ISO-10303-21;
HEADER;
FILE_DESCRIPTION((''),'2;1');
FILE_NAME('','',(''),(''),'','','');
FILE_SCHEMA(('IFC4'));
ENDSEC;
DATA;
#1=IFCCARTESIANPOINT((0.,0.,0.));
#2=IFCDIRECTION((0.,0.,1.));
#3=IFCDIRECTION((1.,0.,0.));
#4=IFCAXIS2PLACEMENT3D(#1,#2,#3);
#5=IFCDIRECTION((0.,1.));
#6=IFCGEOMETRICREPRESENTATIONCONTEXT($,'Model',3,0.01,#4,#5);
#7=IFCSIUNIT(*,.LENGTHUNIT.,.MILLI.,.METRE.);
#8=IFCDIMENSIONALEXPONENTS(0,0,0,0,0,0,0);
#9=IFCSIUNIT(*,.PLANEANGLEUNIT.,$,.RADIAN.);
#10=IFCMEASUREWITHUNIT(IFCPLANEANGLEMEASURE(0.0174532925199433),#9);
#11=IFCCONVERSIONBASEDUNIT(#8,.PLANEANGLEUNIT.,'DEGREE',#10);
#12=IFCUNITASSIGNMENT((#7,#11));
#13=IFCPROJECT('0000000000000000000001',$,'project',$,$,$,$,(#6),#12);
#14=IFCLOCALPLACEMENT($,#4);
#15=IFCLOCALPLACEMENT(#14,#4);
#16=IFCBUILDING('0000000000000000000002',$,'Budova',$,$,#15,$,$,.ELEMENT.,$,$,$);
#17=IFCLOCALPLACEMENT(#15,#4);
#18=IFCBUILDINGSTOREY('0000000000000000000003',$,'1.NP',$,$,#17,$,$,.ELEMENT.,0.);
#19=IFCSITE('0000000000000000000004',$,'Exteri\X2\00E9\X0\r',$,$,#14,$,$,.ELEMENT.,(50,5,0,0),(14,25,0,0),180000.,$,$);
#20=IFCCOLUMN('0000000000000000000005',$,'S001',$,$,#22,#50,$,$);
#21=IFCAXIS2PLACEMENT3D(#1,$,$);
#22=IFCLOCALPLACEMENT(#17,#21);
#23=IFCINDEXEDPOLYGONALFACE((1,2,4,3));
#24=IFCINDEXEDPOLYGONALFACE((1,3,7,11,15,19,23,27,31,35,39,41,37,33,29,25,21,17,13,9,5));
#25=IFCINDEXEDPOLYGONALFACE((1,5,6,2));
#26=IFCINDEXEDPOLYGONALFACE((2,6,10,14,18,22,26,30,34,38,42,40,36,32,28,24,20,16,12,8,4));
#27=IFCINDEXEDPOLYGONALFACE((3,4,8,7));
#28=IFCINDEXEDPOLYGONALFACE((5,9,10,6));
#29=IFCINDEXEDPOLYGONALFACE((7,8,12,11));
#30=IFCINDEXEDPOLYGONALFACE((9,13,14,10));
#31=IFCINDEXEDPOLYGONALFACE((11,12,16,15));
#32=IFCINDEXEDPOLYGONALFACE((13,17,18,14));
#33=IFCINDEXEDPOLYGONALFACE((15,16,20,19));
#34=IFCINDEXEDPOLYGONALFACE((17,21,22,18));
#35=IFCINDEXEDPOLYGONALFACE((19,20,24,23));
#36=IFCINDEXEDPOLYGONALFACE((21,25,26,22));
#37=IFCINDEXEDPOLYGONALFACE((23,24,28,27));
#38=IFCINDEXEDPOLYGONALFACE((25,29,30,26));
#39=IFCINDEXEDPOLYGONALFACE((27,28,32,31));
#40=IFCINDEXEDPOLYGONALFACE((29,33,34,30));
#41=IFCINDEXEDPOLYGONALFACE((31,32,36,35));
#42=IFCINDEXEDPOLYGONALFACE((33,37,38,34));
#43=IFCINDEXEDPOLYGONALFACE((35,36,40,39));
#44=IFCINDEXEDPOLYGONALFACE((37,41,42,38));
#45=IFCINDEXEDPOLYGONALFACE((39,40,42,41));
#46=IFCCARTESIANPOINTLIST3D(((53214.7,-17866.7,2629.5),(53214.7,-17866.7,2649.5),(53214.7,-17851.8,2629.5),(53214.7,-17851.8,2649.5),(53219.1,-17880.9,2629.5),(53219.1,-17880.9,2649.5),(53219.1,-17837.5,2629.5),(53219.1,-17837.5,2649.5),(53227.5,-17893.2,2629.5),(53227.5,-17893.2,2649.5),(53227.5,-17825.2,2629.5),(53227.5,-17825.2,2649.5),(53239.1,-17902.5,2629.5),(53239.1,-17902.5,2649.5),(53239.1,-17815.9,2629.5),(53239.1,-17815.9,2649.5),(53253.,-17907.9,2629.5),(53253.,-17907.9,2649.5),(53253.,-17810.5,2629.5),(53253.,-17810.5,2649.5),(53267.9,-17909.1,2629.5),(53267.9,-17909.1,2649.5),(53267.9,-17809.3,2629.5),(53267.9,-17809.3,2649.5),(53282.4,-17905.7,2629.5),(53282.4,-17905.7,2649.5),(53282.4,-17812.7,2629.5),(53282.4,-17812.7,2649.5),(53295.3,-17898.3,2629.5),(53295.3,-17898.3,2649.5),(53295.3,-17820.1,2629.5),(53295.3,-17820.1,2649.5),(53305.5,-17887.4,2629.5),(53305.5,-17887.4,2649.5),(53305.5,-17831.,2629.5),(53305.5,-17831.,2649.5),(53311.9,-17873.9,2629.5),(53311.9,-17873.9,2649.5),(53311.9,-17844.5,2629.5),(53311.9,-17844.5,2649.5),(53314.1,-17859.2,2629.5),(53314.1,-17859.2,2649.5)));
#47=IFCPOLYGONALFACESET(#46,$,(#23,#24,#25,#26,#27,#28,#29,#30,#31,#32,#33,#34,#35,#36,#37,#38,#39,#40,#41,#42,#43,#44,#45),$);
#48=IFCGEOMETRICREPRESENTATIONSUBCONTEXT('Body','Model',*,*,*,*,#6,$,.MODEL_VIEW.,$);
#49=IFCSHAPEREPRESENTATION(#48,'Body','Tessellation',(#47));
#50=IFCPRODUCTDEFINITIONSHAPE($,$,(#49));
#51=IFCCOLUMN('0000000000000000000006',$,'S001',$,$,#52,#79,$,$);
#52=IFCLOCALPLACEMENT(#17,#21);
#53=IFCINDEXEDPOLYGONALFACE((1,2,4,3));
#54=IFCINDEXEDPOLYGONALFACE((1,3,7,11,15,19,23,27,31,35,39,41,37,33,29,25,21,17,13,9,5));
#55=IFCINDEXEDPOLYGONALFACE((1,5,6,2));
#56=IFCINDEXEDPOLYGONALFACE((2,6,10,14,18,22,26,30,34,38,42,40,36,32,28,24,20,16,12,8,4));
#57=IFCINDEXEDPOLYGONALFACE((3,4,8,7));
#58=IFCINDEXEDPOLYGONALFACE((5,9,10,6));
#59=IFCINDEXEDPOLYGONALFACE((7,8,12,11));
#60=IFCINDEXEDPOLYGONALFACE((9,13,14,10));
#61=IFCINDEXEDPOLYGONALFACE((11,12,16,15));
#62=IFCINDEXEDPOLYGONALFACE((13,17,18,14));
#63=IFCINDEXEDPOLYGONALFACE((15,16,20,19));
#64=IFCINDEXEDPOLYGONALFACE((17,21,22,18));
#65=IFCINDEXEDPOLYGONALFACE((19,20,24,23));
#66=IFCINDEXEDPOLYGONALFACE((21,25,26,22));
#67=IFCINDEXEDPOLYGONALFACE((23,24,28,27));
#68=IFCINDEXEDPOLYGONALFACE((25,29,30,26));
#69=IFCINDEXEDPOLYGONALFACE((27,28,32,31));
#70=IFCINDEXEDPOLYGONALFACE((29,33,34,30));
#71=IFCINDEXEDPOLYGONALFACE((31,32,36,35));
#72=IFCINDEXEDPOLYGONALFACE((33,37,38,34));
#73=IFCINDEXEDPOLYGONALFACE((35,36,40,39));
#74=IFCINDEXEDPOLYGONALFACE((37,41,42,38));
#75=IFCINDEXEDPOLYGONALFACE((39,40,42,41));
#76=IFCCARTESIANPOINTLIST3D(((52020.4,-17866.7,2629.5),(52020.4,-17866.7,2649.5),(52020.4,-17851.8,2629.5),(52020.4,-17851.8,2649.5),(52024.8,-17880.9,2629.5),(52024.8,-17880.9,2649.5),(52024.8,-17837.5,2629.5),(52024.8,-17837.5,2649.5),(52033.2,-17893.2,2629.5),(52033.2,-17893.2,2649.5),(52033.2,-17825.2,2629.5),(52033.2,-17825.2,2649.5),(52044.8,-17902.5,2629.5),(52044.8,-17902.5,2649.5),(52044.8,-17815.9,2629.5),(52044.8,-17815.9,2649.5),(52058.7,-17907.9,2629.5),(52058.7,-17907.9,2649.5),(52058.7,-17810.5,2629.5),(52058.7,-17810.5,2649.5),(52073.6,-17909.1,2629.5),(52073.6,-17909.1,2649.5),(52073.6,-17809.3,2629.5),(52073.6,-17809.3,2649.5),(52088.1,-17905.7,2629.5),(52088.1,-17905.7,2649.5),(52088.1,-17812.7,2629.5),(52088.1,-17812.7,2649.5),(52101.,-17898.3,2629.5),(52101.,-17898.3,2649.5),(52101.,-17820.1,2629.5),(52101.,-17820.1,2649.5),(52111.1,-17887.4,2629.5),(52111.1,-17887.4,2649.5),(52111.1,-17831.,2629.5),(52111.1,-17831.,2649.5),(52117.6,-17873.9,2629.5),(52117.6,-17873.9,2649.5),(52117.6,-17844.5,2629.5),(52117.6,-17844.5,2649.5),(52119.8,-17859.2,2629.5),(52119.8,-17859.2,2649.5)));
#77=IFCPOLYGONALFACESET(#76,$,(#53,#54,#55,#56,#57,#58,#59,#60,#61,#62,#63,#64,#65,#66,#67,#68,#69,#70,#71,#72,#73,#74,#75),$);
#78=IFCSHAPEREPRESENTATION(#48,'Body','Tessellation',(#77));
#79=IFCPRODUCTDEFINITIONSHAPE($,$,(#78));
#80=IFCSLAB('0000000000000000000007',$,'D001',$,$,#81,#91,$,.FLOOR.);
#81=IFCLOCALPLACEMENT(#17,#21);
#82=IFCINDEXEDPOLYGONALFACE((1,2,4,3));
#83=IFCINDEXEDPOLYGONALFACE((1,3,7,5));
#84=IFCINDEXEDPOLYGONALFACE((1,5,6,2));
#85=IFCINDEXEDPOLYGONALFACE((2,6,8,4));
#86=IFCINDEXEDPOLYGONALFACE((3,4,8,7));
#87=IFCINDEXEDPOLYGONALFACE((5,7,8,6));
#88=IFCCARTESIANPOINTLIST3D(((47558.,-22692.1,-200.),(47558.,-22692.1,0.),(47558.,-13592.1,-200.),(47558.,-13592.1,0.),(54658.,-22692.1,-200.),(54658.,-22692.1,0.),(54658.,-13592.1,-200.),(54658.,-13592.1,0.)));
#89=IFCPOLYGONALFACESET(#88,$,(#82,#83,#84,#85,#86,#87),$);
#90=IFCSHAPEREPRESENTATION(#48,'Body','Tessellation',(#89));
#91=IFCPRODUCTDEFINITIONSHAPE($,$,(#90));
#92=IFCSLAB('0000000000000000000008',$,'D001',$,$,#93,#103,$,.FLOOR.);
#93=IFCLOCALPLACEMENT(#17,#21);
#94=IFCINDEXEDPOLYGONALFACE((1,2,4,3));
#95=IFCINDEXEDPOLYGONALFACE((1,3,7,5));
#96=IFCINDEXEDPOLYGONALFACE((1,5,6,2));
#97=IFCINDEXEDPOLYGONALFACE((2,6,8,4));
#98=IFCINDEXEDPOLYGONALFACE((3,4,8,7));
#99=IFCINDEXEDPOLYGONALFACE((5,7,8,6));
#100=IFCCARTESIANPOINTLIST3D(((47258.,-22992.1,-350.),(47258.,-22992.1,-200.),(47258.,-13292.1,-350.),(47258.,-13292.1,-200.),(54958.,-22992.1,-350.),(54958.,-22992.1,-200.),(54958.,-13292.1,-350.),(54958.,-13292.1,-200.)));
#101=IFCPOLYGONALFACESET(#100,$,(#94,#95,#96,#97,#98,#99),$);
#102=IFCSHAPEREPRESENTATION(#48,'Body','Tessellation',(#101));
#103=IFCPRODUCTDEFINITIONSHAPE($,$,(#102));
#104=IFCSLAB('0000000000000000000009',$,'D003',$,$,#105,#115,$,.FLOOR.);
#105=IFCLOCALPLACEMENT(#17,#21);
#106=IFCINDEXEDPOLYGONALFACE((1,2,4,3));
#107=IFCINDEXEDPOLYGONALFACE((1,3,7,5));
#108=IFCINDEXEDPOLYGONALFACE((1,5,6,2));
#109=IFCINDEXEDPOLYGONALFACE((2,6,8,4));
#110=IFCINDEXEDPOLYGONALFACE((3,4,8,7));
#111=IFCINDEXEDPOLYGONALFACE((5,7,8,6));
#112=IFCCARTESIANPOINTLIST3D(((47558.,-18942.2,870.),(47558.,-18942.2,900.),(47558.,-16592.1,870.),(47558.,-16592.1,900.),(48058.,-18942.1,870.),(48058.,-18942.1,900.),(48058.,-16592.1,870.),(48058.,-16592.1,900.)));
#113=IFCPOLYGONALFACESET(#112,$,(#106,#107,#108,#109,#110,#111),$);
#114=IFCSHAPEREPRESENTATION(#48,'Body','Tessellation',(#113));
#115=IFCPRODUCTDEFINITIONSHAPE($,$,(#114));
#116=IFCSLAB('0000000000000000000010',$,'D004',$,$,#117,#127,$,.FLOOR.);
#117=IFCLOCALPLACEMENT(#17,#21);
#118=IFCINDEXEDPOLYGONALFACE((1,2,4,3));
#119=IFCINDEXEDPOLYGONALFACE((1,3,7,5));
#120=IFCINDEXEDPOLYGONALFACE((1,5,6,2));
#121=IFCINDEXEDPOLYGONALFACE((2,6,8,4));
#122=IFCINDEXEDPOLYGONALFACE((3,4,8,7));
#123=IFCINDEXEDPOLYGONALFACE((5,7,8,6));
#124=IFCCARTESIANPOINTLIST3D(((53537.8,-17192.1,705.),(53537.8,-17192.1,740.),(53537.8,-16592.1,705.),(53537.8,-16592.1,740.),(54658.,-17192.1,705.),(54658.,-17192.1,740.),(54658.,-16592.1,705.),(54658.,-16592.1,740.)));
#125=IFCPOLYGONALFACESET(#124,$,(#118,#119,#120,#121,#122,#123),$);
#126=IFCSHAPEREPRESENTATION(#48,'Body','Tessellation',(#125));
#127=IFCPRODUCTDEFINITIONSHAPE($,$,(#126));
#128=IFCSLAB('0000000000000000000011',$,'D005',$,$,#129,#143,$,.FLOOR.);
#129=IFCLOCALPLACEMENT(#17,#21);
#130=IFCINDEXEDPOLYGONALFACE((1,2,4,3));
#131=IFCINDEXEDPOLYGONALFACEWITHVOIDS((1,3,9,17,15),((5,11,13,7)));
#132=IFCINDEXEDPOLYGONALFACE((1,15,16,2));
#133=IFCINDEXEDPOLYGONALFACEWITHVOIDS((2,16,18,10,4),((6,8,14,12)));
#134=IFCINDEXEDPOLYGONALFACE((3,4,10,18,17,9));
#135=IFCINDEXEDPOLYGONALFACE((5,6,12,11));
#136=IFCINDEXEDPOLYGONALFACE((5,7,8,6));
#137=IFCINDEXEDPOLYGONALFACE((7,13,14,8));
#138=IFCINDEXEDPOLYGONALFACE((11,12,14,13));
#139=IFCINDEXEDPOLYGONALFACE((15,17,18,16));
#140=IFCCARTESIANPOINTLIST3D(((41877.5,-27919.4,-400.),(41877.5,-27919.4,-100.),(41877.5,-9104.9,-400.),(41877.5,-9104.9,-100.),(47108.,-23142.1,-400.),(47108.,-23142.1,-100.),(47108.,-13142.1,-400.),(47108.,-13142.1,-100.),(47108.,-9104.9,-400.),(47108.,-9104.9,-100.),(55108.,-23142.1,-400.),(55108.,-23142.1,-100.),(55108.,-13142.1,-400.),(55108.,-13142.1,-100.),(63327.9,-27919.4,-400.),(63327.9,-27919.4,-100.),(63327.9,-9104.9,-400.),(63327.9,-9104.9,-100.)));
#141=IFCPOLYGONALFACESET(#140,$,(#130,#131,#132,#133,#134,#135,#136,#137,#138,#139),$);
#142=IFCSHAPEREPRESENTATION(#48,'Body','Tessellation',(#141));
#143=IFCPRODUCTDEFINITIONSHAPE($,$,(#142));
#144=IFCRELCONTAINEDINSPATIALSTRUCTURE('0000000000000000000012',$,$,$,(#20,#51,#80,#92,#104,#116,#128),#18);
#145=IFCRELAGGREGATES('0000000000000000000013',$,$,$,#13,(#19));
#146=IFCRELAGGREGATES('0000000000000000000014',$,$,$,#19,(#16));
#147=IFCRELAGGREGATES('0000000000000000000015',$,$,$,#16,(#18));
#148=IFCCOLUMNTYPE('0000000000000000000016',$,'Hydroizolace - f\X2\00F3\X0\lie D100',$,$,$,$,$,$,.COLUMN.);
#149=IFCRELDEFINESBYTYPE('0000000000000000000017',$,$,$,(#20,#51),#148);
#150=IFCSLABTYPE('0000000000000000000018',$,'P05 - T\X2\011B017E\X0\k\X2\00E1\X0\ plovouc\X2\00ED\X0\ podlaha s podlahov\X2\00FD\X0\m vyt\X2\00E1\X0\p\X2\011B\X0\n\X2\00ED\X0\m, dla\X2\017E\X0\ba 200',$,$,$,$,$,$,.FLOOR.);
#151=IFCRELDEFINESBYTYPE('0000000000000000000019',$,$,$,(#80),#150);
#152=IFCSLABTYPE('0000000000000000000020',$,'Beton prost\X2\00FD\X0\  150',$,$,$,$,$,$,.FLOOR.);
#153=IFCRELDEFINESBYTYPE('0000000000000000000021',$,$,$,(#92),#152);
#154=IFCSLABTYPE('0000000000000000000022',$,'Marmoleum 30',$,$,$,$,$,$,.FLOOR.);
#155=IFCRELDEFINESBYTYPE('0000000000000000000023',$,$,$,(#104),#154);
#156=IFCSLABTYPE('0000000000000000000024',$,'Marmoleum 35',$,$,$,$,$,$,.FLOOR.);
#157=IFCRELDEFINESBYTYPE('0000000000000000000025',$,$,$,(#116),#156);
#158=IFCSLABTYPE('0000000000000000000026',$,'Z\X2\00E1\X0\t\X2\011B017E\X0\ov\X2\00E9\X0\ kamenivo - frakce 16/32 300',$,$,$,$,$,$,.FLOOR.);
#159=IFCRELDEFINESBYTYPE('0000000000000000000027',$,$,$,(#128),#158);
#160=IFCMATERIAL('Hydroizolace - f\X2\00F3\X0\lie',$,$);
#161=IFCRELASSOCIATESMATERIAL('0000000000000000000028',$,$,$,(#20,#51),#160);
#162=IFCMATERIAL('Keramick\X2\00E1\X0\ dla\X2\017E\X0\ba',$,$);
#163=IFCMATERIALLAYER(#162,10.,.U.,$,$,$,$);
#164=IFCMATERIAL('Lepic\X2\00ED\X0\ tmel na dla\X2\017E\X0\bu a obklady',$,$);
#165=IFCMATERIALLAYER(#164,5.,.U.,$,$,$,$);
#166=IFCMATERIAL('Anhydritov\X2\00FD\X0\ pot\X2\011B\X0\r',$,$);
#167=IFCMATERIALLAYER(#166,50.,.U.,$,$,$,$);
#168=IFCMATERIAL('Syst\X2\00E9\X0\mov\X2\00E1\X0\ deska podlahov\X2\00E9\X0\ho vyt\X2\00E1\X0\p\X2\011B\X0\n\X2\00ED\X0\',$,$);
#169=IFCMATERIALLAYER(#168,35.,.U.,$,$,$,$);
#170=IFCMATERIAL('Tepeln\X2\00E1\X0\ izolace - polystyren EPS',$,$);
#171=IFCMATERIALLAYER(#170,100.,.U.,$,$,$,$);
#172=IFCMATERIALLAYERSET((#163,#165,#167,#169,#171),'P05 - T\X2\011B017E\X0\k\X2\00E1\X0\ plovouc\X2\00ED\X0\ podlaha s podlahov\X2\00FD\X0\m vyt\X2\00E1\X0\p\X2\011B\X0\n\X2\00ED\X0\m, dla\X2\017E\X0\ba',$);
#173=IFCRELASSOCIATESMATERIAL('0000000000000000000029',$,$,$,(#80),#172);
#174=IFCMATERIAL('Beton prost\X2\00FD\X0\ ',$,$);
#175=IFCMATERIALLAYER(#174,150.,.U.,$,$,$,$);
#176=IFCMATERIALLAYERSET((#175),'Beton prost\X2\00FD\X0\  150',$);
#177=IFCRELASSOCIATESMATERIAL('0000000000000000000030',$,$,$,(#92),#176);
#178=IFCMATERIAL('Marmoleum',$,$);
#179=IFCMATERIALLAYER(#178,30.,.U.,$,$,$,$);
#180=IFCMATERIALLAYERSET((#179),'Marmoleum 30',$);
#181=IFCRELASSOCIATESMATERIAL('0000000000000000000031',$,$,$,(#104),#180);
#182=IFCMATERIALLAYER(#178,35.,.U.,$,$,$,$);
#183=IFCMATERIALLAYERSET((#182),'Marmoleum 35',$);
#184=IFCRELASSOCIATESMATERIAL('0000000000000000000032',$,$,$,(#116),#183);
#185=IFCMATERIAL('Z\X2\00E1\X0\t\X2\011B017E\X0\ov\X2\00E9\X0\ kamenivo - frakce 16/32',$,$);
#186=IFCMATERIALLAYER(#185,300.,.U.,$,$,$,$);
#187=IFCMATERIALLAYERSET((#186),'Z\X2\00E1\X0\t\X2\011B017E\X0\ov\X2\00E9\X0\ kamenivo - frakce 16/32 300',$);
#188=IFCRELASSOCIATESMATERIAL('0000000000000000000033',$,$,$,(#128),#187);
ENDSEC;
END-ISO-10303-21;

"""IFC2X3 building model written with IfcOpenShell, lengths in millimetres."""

from ifc_helpers import new_model, entity, si_unit, converted_unit, direction, frame, origin_with_axes, origin_2d_with_axis, place, context, subcontext, project, spatial, polyline, circle, outline, extrude, material, layer, layer_set, layer_usage, type_object, element, save


model = new_model("IFC2X3")

# Units and contexts
model_context = context("Model", 3, precision=0.01, world=origin_with_axes(), true_north=direction((0.0, 1.0)))
body_context = subcontext(model_context, "Body", "Model", "MODEL_VIEW")
ifc_project = project(units=[si_unit("LENGTHUNIT", "METRE", prefix="MILLI"), converted_unit("PLANEANGLEUNIT", "DEGREE", entity("IfcPlaneAngleMeasure", 0.0174532925199433), si_unit("PLANEANGLEUNIT", "RADIAN"), dimensions=[0, 0, 0, 0, 0, 0, 0])], contexts=[model_context])

# Site, building, storey
site_placement = place(None, origin_with_axes())
site = spatial("IfcSite", under=ifc_project, at=site_placement, Name="Exteriér", CompositionType="ELEMENT", RefLatitude=(50, 5, 0, 0), RefLongitude=(14, 25, 0, 0), RefElevation=180000.0)
building_placement = place(site_placement, origin_with_axes())
building = spatial("IfcBuilding", under=site, at=building_placement, Name="Budova", CompositionType="ELEMENT")
storey_placement = place(building_placement, origin_with_axes())
storey = spatial("IfcBuildingStorey", under=building, at=storey_placement, Name="1.NP", CompositionType="ELEMENT", Elevation=0.0)

# Columns
ifc_material_1 = material(Name="Hydroizolace - fólie")
column_type = type_object("IfcColumnType", Name="Hydroizolace - fólie D100", PredefinedType="COLUMN")
for number, where, z_axis, x_axis, name in (
    (1, (53264.1, -17859.2, 2629.5), (0.0, 0.0, 1.0), (1.0, 0.0, 0.0), "S001"),
    (2, (52069.8, -17859.2, 2629.5), (0.0, 0.0, 1.0), (1.0, 0.0, 0.0), "S001"),
):
    element("IfcColumn", number, at=place(storey_placement, frame(where, z_axis=z_axis, x_axis=x_axis)), inside=storey, type_object=column_type, material=ifc_material_1, Name=name, context=body_context, shape_type="SweptSolid", body=[
        extrude(circle(Radius=50.0, at=origin_2d_with_axis()), origin_with_axes(), (0.0, 0.0, 1.0), 20.0),
    ])

# Slabs
ifc_material_2 = material(Name="Keramická dlažba")
ifc_layer_1 = layer(ifc_material_2, 10.0, ventilated="UNKNOWN")
ifc_material_3 = material(Name="Lepicí tmel na dlažbu a obklady")
ifc_layer_2 = layer(ifc_material_3, 5.0, ventilated="UNKNOWN")
ifc_material_4 = material(Name="Anhydritový potěr")
ifc_layer_3 = layer(ifc_material_4, 50.0, ventilated="UNKNOWN")
ifc_material_5 = material(Name="Systémová deska podlahového vytápění")
ifc_layer_4 = layer(ifc_material_5, 35.0, ventilated="UNKNOWN")
ifc_material_6 = material(Name="Tepelná izolace - polystyren EPS")
ifc_layer_5 = layer(ifc_material_6, 100.0, ventilated="UNKNOWN")
ifc_layer_set_1 = layer_set([ifc_layer_1, ifc_layer_2, ifc_layer_3, ifc_layer_4, ifc_layer_5], Name="P05 - Těžká plovoucí podlaha s podlahovým vytápěním, dlažba")
ifc_layer_usage_1 = layer_usage(ifc_layer_set_1, "AXIS3", "NEGATIVE", 200.0)
slab_type_1 = type_object("IfcSlabType", Name="P05 - Těžká plovoucí podlaha s podlahovým vytápěním, dlažba 200", PredefinedType="FLOOR")
slab_1_placement = place(storey_placement, frame((47558.0, -13592.1, 0.0), z_axis=(0.0, 0.0, 1.0), x_axis=(1.0, 0.0, 0.0)))
element("IfcSlab", 3, at=slab_1_placement, inside=storey, type_object=slab_type_1, material=ifc_layer_usage_1, Name="D001", PredefinedType="FLOOR", context=body_context, shape_type="SweptSolid", body=[
    extrude(outline(polyline([(0.0, 0.0), (0.0, -9100.0), (7100.0, -9100.0), (7100.0, 0.0), (0.0, 0.0)])), frame((0.0, 0.0, -200.0), z_axis=(0.0, 0.0, 1.0), x_axis=(1.0, 0.0, 0.0)), (0.0, 0.0, 1.0), 200.0),
])
ifc_material_7 = material(Name="Beton prostý ")
ifc_layer_6 = layer(ifc_material_7, 150.0, ventilated="UNKNOWN")
ifc_layer_set_2 = layer_set([ifc_layer_6], Name="Beton prostý  150")
ifc_layer_usage_2 = layer_usage(ifc_layer_set_2, "AXIS3", "NEGATIVE", 150.0)
slab_type_2 = type_object("IfcSlabType", Name="Beton prostý  150", PredefinedType="FLOOR")
slab_2_placement = place(storey_placement, frame((47258.0, -13292.1, -200.0), z_axis=(0.0, 0.0, 1.0), x_axis=(1.0, 0.0, 0.0)))
element("IfcSlab", 4, at=slab_2_placement, inside=storey, type_object=slab_type_2, material=ifc_layer_usage_2, Name="D001", PredefinedType="FLOOR", context=body_context, shape_type="SweptSolid", body=[
    extrude(outline(polyline([(0.0, 0.0), (0.0, -9700.0), (7700.0, -9700.0), (7700.0, 0.0), (0.0, 0.0)])), frame((0.0, 0.0, -150.0), z_axis=(0.0, 0.0, 1.0), x_axis=(1.0, 0.0, 0.0)), (0.0, 0.0, 1.0), 150.0),
])
ifc_material_8 = material(Name="Marmoleum")
ifc_layer_7 = layer(ifc_material_8, 30.0, ventilated="UNKNOWN")
ifc_layer_set_3 = layer_set([ifc_layer_7], Name="Marmoleum 30")
ifc_layer_usage_3 = layer_usage(ifc_layer_set_3, "AXIS3", "NEGATIVE", 30.0)
slab_type_3 = type_object("IfcSlabType", Name="Marmoleum 30", PredefinedType="FLOOR")
slab_3_placement = place(storey_placement, frame((47558.0, -16592.1, 900.0), z_axis=(0.0, 0.0, 1.0), x_axis=(1.0, 0.0, 0.0)))
element("IfcSlab", 5, at=slab_3_placement, inside=storey, type_object=slab_type_3, material=ifc_layer_usage_3, Name="D003", PredefinedType="FLOOR", context=body_context, shape_type="SweptSolid", body=[
    extrude(outline(polyline([(0.0, 0.0), (0.0, -2350.2), (500.0, -2350.0), (500.0, 0.0), (0.0, 0.0)])), frame((0.0, 0.0, -30.0), z_axis=(0.0, 0.0, 1.0), x_axis=(1.0, 0.0, 0.0)), (0.0, 0.0, 1.0), 30.0),
])
ifc_layer_8 = layer(ifc_material_8, 35.0, ventilated="UNKNOWN")
ifc_layer_set_4 = layer_set([ifc_layer_8], Name="Marmoleum 35")
ifc_layer_usage_4 = layer_usage(ifc_layer_set_4, "AXIS3", "NEGATIVE", 35.0)
slab_type_4 = type_object("IfcSlabType", Name="Marmoleum 35", PredefinedType="FLOOR")
slab_4_placement = place(storey_placement, frame((54658.0, -16592.1, 740.0), z_axis=(0.0, 0.0, 1.0), x_axis=(1.0, 0.0, 0.0)))
element("IfcSlab", 6, at=slab_4_placement, inside=storey, type_object=slab_type_4, material=ifc_layer_usage_4, Name="D004", PredefinedType="FLOOR", context=body_context, shape_type="SweptSolid", body=[
    extrude(outline(polyline([(0.0, 0.0), (-1120.2, 0.0), (-1120.2, -600.0), (0.0, -600.0), (0.0, 0.0)])), frame((0.0, 0.0, -35.0), z_axis=(0.0, 0.0, 1.0), x_axis=(1.0, 0.0, 0.0)), (0.0, 0.0, 1.0), 35.0),
])
ifc_material_9 = material(Name="Zátěžové kamenivo - frakce 16/32")
ifc_layer_9 = layer(ifc_material_9, 300.0, ventilated="UNKNOWN")
ifc_layer_set_5 = layer_set([ifc_layer_9], Name="Zátěžové kamenivo - frakce 16/32 300")
ifc_layer_usage_5 = layer_usage(ifc_layer_set_5, "AXIS3", "NEGATIVE", 300.0)
slab_type_5 = type_object("IfcSlabType", Name="Zátěžové kamenivo - frakce 16/32 300", PredefinedType="FLOOR")
slab_5_placement = place(storey_placement, frame((47108.0, -9104.9, -100.0), z_axis=(0.0, 0.0, 1.0), x_axis=(1.0, 0.0, 0.0)))
element("IfcSlab", 7, at=slab_5_placement, inside=storey, type_object=slab_type_5, material=ifc_layer_usage_5, Name="D005", PredefinedType="FLOOR", context=body_context, shape_type="SweptSolid", body=[
    extrude(outline(polyline([(0.0, 0.0), (-5230.4, 0.0), (-5230.4, -18814.5), (16219.9, -18814.5), (16219.9, 0.0), (0.0, 0.0)]), holes=[polyline([(0.0, -14037.2), (0.0, -4037.2), (8000.0, -4037.2), (8000.0, -14037.2), (0.0, -14037.2)])]), frame((0.0, 0.0, -300.0), z_axis=(0.0, 0.0, 1.0), x_axis=(1.0, 0.0, 0.0)), (0.0, 0.0, 1.0), 300.0),
])

save(model, "model.ifc")
